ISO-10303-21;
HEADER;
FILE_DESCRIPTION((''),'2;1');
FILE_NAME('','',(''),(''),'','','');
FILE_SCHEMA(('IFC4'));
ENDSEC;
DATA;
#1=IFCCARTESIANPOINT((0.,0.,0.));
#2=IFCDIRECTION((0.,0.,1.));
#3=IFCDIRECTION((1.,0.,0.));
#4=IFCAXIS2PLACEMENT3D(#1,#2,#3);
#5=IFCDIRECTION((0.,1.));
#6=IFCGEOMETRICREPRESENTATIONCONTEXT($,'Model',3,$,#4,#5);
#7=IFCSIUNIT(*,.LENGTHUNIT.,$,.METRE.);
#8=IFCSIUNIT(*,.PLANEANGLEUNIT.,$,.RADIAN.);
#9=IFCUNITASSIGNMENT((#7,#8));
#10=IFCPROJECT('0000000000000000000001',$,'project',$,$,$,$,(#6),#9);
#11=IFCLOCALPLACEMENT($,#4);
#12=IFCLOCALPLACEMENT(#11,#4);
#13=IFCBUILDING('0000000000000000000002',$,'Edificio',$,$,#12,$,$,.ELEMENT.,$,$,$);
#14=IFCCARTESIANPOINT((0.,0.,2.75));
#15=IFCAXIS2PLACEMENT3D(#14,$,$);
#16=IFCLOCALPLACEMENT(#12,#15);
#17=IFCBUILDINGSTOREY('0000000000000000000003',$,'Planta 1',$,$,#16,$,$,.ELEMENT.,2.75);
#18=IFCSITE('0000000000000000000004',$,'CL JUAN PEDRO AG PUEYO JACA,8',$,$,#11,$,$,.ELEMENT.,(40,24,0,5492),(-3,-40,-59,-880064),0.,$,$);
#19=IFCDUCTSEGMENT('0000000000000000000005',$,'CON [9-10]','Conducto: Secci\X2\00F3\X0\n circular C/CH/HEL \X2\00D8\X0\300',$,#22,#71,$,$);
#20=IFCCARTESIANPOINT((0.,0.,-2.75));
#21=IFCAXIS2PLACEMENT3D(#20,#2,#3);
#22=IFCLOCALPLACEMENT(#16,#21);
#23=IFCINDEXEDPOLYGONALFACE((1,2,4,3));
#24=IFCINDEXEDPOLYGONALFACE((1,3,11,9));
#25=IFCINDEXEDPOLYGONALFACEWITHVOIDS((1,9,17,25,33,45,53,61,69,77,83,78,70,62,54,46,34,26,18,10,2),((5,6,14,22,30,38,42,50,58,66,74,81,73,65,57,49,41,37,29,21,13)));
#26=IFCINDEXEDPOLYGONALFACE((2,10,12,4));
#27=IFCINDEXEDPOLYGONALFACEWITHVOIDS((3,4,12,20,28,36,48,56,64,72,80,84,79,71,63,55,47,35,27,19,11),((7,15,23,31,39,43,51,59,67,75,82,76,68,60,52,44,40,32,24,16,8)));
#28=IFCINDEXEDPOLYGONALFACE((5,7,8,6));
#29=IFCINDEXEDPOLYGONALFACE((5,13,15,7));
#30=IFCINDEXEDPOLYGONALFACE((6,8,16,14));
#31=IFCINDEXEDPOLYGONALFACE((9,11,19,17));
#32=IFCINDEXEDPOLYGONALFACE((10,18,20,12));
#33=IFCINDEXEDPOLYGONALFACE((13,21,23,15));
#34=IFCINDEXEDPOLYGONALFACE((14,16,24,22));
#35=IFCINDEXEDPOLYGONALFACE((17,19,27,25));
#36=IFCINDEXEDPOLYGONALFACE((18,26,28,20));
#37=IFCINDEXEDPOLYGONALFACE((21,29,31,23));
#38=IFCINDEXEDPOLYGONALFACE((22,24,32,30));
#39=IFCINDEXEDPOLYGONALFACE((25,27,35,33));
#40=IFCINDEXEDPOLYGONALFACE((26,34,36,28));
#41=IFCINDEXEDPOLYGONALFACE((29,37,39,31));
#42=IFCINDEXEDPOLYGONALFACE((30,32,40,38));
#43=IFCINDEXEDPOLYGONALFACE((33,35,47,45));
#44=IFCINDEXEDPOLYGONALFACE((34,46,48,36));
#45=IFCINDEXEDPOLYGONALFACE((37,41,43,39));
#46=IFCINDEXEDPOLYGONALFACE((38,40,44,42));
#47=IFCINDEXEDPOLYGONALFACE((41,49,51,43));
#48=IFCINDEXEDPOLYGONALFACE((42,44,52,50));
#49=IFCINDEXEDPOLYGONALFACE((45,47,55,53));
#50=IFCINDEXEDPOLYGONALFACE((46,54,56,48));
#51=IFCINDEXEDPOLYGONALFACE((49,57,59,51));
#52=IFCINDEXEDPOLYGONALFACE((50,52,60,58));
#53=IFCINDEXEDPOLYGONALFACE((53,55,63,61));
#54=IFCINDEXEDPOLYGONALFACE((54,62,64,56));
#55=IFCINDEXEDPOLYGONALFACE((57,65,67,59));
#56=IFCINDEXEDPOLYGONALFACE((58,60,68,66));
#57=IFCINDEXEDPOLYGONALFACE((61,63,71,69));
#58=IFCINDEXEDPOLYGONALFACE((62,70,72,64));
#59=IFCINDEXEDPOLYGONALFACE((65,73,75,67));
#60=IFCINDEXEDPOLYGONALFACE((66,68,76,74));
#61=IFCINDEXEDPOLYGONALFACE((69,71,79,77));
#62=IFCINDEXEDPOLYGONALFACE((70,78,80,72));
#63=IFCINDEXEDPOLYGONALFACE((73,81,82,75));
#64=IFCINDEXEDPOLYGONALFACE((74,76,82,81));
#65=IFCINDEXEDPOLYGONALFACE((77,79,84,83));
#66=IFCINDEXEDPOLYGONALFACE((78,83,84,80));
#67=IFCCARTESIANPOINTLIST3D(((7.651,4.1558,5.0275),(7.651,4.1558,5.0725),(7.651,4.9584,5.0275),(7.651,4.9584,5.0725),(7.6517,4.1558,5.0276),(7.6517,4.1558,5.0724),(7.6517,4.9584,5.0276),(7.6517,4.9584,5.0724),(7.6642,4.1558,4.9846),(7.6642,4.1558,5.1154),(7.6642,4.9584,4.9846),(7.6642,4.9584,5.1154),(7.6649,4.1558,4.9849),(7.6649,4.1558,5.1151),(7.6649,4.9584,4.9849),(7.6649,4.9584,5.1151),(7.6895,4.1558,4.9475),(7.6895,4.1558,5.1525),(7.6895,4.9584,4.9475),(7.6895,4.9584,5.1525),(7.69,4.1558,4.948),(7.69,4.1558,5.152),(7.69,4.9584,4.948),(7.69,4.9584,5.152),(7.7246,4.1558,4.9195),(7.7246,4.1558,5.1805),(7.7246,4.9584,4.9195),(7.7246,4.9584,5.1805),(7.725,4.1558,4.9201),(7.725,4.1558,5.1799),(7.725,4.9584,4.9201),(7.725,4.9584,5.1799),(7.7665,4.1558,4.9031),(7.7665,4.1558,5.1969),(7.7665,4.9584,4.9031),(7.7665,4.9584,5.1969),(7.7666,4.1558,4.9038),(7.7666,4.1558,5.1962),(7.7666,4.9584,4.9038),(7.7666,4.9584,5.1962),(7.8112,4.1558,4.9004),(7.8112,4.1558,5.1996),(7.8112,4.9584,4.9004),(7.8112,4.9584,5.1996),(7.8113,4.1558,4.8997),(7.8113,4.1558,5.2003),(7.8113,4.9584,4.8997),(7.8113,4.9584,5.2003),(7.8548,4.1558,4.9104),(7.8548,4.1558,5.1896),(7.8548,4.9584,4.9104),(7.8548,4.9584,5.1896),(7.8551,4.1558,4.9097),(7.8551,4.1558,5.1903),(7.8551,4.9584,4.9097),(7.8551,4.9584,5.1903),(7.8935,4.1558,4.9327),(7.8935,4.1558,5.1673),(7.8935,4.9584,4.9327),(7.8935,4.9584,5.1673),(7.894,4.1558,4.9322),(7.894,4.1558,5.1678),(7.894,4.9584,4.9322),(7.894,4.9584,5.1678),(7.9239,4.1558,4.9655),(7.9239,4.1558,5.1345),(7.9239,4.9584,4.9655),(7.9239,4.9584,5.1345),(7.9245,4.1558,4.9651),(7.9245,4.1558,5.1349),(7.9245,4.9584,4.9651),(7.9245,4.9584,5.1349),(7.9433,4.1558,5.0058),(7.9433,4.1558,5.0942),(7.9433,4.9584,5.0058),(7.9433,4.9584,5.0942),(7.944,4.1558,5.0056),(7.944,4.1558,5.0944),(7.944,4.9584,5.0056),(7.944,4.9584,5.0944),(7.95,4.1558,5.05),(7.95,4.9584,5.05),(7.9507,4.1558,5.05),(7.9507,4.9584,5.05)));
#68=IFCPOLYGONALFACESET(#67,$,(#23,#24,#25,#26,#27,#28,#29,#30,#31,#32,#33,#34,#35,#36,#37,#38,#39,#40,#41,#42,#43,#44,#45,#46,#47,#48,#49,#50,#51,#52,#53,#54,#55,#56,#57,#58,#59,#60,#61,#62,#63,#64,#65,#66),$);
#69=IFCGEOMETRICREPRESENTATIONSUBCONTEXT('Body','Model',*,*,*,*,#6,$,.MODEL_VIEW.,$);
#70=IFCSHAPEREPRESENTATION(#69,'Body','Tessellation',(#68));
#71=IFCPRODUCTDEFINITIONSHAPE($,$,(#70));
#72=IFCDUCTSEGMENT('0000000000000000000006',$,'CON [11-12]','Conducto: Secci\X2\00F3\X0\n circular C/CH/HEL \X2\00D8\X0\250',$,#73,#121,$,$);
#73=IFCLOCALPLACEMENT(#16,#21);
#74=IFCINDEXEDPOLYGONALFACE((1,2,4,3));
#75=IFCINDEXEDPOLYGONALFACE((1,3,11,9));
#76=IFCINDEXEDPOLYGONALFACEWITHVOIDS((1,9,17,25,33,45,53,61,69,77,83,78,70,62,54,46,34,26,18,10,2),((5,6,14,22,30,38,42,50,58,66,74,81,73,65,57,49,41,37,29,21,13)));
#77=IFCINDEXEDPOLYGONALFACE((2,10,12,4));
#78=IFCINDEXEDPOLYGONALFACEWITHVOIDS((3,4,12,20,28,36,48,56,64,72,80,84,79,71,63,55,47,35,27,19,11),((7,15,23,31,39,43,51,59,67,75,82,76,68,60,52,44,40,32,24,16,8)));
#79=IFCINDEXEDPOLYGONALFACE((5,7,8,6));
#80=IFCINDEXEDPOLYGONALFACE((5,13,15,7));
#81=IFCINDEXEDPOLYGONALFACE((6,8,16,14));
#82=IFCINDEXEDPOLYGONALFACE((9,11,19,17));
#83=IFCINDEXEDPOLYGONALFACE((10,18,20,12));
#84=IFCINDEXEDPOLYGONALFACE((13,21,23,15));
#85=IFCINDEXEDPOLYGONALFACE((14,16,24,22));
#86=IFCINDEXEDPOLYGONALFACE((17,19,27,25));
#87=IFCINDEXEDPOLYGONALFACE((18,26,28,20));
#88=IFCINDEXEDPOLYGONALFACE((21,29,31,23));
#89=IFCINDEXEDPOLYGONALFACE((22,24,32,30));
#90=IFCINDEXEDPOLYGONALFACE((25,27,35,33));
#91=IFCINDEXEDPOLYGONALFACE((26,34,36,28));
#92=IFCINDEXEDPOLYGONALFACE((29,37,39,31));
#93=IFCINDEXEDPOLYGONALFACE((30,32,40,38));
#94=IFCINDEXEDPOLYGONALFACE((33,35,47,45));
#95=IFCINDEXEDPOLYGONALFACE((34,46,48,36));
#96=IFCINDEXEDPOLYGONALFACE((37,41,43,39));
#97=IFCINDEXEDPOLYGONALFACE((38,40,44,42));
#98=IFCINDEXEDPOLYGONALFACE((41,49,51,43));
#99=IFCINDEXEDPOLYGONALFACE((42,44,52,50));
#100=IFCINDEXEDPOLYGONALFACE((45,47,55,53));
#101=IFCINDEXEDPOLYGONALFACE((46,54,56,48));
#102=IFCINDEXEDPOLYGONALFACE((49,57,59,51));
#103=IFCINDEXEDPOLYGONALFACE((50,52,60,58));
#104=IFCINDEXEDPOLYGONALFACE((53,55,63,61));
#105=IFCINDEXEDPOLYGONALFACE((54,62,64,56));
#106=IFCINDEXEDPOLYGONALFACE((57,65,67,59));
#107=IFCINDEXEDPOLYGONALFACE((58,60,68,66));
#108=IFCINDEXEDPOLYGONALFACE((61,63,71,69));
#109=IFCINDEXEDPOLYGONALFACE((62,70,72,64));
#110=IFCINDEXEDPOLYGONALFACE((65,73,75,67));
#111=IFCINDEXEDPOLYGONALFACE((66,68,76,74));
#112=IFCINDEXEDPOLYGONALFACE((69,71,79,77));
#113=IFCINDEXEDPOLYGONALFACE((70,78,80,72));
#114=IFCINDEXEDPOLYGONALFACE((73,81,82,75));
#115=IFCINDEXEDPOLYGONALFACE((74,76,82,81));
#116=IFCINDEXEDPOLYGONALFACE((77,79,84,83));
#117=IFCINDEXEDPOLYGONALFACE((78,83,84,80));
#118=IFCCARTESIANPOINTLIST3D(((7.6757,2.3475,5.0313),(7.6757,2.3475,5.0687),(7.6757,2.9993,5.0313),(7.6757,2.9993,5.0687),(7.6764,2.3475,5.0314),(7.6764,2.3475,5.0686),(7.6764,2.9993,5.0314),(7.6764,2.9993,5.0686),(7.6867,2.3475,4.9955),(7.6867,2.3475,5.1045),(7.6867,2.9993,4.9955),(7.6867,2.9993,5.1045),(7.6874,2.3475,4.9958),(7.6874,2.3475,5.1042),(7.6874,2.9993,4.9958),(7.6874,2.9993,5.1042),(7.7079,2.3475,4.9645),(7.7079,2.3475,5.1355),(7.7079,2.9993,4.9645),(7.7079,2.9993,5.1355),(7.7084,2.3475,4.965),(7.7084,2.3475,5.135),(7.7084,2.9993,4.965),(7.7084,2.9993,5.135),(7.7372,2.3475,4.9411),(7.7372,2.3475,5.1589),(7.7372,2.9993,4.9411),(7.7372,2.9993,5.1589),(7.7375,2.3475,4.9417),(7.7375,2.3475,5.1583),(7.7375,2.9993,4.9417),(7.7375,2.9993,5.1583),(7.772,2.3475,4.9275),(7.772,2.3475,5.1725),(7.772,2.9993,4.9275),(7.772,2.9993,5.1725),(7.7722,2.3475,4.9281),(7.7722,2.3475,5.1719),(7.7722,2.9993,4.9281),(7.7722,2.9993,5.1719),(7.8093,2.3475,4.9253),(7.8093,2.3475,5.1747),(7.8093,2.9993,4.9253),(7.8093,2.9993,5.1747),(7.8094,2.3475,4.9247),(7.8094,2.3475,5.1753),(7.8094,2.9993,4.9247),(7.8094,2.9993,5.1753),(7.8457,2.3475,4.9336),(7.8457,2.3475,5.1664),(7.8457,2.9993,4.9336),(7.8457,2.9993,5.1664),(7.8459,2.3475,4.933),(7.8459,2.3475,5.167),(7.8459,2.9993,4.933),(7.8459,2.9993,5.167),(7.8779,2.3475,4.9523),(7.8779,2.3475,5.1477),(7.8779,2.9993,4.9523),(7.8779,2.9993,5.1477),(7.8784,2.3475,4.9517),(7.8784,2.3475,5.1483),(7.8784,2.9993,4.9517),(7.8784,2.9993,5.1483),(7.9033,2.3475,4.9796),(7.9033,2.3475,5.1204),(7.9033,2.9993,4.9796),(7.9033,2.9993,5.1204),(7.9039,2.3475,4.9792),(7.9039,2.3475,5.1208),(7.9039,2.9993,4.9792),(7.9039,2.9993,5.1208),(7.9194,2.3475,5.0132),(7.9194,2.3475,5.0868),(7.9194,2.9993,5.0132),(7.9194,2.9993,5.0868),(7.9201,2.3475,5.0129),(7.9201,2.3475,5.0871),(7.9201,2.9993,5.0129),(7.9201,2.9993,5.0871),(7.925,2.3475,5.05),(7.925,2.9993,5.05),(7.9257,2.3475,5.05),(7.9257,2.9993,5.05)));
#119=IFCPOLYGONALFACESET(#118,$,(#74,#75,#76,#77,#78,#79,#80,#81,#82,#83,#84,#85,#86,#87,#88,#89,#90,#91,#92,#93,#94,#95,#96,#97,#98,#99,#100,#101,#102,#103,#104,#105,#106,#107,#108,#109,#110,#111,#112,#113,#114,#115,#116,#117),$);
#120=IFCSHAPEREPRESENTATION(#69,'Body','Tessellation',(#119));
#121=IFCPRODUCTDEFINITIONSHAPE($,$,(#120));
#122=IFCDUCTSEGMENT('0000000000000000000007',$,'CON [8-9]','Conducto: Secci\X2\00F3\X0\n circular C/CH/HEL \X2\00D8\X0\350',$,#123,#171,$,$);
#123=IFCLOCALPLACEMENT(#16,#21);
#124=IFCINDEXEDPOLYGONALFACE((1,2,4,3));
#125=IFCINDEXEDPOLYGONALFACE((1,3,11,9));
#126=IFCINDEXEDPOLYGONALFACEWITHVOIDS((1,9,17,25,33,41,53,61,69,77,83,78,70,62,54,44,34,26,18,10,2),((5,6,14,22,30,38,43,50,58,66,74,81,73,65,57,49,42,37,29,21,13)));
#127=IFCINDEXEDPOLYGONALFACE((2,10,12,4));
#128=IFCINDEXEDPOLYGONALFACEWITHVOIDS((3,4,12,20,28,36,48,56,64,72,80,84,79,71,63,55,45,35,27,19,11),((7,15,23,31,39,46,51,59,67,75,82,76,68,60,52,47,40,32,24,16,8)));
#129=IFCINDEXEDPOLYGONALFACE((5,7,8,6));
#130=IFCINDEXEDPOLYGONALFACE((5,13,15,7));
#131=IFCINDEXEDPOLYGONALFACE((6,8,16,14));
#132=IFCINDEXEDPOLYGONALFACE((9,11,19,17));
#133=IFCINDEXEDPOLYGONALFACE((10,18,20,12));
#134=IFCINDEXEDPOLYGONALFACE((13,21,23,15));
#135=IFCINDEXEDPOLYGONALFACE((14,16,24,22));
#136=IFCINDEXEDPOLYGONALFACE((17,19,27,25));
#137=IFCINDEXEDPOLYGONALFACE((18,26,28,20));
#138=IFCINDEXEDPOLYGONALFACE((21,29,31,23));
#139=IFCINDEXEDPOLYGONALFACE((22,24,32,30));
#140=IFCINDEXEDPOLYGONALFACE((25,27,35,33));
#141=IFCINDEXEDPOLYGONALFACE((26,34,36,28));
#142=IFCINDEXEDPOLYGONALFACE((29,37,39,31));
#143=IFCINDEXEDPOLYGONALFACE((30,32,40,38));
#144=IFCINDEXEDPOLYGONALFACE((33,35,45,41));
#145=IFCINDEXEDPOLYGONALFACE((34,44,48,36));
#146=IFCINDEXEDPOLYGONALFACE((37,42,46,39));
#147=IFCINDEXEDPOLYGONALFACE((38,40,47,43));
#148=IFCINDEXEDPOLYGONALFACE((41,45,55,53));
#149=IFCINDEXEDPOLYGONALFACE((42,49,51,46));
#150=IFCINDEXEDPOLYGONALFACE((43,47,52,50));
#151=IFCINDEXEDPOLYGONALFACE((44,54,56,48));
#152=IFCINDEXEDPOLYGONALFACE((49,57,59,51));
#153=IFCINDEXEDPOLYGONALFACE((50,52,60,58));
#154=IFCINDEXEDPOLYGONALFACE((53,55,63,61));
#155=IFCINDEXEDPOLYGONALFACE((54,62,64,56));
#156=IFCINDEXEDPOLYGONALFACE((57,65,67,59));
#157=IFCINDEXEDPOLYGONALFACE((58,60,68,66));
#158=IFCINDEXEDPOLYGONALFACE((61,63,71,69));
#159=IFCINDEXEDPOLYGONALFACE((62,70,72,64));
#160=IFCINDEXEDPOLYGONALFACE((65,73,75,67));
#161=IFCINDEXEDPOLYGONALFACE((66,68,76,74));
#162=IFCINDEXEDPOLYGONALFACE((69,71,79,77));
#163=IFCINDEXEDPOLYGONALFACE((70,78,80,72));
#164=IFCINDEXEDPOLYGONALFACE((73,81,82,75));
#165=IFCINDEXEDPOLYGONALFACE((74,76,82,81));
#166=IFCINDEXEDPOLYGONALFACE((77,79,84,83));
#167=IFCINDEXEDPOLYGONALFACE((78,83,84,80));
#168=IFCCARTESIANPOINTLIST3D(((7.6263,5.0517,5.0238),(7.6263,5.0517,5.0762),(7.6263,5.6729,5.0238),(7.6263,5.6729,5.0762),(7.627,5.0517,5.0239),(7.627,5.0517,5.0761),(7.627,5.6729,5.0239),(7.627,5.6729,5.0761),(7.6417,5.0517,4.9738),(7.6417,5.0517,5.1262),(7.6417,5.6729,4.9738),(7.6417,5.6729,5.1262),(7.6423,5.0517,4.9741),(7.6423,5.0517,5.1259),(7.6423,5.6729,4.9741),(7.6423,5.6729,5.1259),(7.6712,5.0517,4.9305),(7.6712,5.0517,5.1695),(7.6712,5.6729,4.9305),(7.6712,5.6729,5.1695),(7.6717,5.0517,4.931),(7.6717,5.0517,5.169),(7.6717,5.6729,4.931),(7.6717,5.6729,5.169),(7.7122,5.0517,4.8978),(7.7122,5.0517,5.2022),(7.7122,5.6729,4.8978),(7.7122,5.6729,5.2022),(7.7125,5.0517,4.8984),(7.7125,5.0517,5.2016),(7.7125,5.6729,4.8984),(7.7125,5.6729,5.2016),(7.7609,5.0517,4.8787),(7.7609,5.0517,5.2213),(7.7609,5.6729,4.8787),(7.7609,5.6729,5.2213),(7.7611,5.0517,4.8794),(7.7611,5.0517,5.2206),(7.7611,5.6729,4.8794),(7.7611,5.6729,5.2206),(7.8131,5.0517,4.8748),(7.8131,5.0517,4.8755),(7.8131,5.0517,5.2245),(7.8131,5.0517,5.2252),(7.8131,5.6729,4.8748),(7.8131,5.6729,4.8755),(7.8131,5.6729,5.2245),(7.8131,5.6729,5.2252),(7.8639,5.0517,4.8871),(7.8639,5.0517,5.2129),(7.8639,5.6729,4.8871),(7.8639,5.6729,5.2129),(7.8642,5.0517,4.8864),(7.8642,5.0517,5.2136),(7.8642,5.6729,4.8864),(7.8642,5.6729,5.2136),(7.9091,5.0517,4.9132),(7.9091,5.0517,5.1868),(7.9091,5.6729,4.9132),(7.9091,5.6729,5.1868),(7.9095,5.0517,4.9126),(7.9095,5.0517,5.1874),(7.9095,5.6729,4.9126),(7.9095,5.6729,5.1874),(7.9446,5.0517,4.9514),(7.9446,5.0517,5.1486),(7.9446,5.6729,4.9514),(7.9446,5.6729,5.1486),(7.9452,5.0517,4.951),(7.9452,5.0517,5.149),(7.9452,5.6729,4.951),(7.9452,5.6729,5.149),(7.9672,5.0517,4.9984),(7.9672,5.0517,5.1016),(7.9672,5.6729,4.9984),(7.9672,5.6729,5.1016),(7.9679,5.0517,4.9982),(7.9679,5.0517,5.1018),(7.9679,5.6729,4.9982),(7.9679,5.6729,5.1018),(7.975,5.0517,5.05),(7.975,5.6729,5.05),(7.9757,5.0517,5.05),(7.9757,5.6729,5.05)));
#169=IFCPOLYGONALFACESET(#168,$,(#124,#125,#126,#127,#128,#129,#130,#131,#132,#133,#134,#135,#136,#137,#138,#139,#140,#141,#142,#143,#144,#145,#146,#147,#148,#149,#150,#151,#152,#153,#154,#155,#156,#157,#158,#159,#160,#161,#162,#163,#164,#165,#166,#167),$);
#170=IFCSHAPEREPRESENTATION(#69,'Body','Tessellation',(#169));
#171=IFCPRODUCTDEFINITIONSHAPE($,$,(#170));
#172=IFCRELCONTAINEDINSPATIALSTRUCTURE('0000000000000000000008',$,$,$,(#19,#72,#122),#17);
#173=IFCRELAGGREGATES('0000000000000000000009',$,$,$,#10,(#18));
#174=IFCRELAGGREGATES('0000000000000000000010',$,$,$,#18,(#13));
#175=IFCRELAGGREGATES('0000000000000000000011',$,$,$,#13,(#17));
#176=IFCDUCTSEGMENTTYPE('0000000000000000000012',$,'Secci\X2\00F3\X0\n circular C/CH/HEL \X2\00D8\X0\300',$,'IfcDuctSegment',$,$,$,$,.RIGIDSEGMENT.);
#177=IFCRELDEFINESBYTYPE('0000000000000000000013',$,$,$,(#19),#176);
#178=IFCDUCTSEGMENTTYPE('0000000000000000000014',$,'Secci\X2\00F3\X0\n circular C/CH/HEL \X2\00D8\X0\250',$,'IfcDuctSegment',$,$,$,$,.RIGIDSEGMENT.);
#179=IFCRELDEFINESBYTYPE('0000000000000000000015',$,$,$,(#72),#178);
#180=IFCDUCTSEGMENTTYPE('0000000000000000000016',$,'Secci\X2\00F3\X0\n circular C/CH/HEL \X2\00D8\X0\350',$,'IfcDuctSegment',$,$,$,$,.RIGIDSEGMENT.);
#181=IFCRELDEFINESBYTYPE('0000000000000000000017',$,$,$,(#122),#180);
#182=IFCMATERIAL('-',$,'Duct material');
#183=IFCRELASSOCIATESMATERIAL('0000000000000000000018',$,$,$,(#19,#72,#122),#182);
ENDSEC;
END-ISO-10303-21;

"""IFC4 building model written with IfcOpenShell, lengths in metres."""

from ifc_helpers import new_model, si_unit, direction, frame, origin_with_axes, origin_2d_with_axis, place, context, subcontext, project, spatial, hollow_circle, extrude, material, type_object, element, save


model = new_model("IFC4")

# Units and contexts
model_context = context("Model", 3, world=origin_with_axes(), true_north=direction((0.0, 1.0)))
body_context = subcontext(model_context, "Body", "Model", "MODEL_VIEW")
ifc_project = project(units=[si_unit("LENGTHUNIT", "METRE"), si_unit("PLANEANGLEUNIT", "RADIAN")], contexts=[model_context])

# Site, building, storey
site_placement = place(None, origin_with_axes())
site = spatial("IfcSite", under=ifc_project, at=site_placement, Name="CL JUAN PEDRO AG PUEYO JACA,8", CompositionType="ELEMENT", RefLatitude=(40, 24, 0, 5492), RefLongitude=(-3, -40, -59, -880064), RefElevation=0.0)
building_placement = place(site_placement, origin_with_axes())
building = spatial("IfcBuilding", under=site, at=building_placement, Name="Edificio", CompositionType="ELEMENT")
storey_placement = place(building_placement, frame((0.0, 0.0, 2.75)))
storey = spatial("IfcBuildingStorey", under=building, at=storey_placement, Name="Planta 1", CompositionType="ELEMENT", Elevation=2.75)

# Shared definitions
ifc_material_1 = material(Name="-", Category="Duct material")

# Duct segments
duct_segment_type_1 = type_object("IfcDuctSegmentType", Name="Sección circular C/CH/HEL Ø300", ApplicableOccurrence="IfcDuctSegment", PredefinedType="RIGIDSEGMENT")
duct_segment_1_placement = place(storey_placement, frame((0.0, 0.0, -2.75), z_axis=(0.0, 0.0, 1.0), x_axis=(1.0, 0.0, 0.0)))
element("IfcDuctSegment", 1, at=duct_segment_1_placement, inside=storey, type_object=duct_segment_type_1, material=ifc_material_1, Name="CON [9-10]", Description="Conducto: Sección circular C/CH/HEL Ø300", context=body_context, shape_type="SweptSolid", body=[
    extrude(hollow_circle(Radius=0.1507, WallThickness=0.0007, at=origin_2d_with_axis()), frame((7.8, 4.9584, 5.05), z_axis=(0.0, -1.0, 0.0), x_axis=(1.0, 0.0, 0.0)), (0.0, 0.0, 1.0), 0.8026),
])
duct_segment_type_2 = type_object("IfcDuctSegmentType", Name="Sección circular C/CH/HEL Ø250", ApplicableOccurrence="IfcDuctSegment", PredefinedType="RIGIDSEGMENT")
duct_segment_2_placement = place(storey_placement, frame((0.0, 0.0, -2.75), z_axis=(0.0, 0.0, 1.0), x_axis=(1.0, 0.0, 0.0)))
element("IfcDuctSegment", 2, at=duct_segment_2_placement, inside=storey, type_object=duct_segment_type_2, material=ifc_material_1, Name="CON [11-12]", Description="Conducto: Sección circular C/CH/HEL Ø250", context=body_context, shape_type="SweptSolid", body=[
    extrude(hollow_circle(Radius=0.1257, WallThickness=0.0007, at=origin_2d_with_axis()), frame((7.8, 2.9993, 5.05), z_axis=(0.0, -1.0, 0.0), x_axis=(1.0, 0.0, 0.0)), (0.0, 0.0, 1.0), 0.6518),
])
duct_segment_type_3 = type_object("IfcDuctSegmentType", Name="Sección circular C/CH/HEL Ø350", ApplicableOccurrence="IfcDuctSegment", PredefinedType="RIGIDSEGMENT")
duct_segment_3_placement = place(storey_placement, frame((0.0, 0.0, -2.75), z_axis=(0.0, 0.0, 1.0), x_axis=(1.0, 0.0, 0.0)))
element("IfcDuctSegment", 3, at=duct_segment_3_placement, inside=storey, type_object=duct_segment_type_3, material=ifc_material_1, Name="CON [8-9]", Description="Conducto: Sección circular C/CH/HEL Ø350", context=body_context, shape_type="SweptSolid", body=[
    extrude(hollow_circle(Radius=0.1757, WallThickness=0.0007, at=origin_2d_with_axis()), frame((7.8, 5.6729, 5.05), z_axis=(0.0, -1.0, 0.0), x_axis=(1.0, 0.0, 0.0)), (0.0, 0.0, 1.0), 0.6212),
])

save(model, "model.ifc")
